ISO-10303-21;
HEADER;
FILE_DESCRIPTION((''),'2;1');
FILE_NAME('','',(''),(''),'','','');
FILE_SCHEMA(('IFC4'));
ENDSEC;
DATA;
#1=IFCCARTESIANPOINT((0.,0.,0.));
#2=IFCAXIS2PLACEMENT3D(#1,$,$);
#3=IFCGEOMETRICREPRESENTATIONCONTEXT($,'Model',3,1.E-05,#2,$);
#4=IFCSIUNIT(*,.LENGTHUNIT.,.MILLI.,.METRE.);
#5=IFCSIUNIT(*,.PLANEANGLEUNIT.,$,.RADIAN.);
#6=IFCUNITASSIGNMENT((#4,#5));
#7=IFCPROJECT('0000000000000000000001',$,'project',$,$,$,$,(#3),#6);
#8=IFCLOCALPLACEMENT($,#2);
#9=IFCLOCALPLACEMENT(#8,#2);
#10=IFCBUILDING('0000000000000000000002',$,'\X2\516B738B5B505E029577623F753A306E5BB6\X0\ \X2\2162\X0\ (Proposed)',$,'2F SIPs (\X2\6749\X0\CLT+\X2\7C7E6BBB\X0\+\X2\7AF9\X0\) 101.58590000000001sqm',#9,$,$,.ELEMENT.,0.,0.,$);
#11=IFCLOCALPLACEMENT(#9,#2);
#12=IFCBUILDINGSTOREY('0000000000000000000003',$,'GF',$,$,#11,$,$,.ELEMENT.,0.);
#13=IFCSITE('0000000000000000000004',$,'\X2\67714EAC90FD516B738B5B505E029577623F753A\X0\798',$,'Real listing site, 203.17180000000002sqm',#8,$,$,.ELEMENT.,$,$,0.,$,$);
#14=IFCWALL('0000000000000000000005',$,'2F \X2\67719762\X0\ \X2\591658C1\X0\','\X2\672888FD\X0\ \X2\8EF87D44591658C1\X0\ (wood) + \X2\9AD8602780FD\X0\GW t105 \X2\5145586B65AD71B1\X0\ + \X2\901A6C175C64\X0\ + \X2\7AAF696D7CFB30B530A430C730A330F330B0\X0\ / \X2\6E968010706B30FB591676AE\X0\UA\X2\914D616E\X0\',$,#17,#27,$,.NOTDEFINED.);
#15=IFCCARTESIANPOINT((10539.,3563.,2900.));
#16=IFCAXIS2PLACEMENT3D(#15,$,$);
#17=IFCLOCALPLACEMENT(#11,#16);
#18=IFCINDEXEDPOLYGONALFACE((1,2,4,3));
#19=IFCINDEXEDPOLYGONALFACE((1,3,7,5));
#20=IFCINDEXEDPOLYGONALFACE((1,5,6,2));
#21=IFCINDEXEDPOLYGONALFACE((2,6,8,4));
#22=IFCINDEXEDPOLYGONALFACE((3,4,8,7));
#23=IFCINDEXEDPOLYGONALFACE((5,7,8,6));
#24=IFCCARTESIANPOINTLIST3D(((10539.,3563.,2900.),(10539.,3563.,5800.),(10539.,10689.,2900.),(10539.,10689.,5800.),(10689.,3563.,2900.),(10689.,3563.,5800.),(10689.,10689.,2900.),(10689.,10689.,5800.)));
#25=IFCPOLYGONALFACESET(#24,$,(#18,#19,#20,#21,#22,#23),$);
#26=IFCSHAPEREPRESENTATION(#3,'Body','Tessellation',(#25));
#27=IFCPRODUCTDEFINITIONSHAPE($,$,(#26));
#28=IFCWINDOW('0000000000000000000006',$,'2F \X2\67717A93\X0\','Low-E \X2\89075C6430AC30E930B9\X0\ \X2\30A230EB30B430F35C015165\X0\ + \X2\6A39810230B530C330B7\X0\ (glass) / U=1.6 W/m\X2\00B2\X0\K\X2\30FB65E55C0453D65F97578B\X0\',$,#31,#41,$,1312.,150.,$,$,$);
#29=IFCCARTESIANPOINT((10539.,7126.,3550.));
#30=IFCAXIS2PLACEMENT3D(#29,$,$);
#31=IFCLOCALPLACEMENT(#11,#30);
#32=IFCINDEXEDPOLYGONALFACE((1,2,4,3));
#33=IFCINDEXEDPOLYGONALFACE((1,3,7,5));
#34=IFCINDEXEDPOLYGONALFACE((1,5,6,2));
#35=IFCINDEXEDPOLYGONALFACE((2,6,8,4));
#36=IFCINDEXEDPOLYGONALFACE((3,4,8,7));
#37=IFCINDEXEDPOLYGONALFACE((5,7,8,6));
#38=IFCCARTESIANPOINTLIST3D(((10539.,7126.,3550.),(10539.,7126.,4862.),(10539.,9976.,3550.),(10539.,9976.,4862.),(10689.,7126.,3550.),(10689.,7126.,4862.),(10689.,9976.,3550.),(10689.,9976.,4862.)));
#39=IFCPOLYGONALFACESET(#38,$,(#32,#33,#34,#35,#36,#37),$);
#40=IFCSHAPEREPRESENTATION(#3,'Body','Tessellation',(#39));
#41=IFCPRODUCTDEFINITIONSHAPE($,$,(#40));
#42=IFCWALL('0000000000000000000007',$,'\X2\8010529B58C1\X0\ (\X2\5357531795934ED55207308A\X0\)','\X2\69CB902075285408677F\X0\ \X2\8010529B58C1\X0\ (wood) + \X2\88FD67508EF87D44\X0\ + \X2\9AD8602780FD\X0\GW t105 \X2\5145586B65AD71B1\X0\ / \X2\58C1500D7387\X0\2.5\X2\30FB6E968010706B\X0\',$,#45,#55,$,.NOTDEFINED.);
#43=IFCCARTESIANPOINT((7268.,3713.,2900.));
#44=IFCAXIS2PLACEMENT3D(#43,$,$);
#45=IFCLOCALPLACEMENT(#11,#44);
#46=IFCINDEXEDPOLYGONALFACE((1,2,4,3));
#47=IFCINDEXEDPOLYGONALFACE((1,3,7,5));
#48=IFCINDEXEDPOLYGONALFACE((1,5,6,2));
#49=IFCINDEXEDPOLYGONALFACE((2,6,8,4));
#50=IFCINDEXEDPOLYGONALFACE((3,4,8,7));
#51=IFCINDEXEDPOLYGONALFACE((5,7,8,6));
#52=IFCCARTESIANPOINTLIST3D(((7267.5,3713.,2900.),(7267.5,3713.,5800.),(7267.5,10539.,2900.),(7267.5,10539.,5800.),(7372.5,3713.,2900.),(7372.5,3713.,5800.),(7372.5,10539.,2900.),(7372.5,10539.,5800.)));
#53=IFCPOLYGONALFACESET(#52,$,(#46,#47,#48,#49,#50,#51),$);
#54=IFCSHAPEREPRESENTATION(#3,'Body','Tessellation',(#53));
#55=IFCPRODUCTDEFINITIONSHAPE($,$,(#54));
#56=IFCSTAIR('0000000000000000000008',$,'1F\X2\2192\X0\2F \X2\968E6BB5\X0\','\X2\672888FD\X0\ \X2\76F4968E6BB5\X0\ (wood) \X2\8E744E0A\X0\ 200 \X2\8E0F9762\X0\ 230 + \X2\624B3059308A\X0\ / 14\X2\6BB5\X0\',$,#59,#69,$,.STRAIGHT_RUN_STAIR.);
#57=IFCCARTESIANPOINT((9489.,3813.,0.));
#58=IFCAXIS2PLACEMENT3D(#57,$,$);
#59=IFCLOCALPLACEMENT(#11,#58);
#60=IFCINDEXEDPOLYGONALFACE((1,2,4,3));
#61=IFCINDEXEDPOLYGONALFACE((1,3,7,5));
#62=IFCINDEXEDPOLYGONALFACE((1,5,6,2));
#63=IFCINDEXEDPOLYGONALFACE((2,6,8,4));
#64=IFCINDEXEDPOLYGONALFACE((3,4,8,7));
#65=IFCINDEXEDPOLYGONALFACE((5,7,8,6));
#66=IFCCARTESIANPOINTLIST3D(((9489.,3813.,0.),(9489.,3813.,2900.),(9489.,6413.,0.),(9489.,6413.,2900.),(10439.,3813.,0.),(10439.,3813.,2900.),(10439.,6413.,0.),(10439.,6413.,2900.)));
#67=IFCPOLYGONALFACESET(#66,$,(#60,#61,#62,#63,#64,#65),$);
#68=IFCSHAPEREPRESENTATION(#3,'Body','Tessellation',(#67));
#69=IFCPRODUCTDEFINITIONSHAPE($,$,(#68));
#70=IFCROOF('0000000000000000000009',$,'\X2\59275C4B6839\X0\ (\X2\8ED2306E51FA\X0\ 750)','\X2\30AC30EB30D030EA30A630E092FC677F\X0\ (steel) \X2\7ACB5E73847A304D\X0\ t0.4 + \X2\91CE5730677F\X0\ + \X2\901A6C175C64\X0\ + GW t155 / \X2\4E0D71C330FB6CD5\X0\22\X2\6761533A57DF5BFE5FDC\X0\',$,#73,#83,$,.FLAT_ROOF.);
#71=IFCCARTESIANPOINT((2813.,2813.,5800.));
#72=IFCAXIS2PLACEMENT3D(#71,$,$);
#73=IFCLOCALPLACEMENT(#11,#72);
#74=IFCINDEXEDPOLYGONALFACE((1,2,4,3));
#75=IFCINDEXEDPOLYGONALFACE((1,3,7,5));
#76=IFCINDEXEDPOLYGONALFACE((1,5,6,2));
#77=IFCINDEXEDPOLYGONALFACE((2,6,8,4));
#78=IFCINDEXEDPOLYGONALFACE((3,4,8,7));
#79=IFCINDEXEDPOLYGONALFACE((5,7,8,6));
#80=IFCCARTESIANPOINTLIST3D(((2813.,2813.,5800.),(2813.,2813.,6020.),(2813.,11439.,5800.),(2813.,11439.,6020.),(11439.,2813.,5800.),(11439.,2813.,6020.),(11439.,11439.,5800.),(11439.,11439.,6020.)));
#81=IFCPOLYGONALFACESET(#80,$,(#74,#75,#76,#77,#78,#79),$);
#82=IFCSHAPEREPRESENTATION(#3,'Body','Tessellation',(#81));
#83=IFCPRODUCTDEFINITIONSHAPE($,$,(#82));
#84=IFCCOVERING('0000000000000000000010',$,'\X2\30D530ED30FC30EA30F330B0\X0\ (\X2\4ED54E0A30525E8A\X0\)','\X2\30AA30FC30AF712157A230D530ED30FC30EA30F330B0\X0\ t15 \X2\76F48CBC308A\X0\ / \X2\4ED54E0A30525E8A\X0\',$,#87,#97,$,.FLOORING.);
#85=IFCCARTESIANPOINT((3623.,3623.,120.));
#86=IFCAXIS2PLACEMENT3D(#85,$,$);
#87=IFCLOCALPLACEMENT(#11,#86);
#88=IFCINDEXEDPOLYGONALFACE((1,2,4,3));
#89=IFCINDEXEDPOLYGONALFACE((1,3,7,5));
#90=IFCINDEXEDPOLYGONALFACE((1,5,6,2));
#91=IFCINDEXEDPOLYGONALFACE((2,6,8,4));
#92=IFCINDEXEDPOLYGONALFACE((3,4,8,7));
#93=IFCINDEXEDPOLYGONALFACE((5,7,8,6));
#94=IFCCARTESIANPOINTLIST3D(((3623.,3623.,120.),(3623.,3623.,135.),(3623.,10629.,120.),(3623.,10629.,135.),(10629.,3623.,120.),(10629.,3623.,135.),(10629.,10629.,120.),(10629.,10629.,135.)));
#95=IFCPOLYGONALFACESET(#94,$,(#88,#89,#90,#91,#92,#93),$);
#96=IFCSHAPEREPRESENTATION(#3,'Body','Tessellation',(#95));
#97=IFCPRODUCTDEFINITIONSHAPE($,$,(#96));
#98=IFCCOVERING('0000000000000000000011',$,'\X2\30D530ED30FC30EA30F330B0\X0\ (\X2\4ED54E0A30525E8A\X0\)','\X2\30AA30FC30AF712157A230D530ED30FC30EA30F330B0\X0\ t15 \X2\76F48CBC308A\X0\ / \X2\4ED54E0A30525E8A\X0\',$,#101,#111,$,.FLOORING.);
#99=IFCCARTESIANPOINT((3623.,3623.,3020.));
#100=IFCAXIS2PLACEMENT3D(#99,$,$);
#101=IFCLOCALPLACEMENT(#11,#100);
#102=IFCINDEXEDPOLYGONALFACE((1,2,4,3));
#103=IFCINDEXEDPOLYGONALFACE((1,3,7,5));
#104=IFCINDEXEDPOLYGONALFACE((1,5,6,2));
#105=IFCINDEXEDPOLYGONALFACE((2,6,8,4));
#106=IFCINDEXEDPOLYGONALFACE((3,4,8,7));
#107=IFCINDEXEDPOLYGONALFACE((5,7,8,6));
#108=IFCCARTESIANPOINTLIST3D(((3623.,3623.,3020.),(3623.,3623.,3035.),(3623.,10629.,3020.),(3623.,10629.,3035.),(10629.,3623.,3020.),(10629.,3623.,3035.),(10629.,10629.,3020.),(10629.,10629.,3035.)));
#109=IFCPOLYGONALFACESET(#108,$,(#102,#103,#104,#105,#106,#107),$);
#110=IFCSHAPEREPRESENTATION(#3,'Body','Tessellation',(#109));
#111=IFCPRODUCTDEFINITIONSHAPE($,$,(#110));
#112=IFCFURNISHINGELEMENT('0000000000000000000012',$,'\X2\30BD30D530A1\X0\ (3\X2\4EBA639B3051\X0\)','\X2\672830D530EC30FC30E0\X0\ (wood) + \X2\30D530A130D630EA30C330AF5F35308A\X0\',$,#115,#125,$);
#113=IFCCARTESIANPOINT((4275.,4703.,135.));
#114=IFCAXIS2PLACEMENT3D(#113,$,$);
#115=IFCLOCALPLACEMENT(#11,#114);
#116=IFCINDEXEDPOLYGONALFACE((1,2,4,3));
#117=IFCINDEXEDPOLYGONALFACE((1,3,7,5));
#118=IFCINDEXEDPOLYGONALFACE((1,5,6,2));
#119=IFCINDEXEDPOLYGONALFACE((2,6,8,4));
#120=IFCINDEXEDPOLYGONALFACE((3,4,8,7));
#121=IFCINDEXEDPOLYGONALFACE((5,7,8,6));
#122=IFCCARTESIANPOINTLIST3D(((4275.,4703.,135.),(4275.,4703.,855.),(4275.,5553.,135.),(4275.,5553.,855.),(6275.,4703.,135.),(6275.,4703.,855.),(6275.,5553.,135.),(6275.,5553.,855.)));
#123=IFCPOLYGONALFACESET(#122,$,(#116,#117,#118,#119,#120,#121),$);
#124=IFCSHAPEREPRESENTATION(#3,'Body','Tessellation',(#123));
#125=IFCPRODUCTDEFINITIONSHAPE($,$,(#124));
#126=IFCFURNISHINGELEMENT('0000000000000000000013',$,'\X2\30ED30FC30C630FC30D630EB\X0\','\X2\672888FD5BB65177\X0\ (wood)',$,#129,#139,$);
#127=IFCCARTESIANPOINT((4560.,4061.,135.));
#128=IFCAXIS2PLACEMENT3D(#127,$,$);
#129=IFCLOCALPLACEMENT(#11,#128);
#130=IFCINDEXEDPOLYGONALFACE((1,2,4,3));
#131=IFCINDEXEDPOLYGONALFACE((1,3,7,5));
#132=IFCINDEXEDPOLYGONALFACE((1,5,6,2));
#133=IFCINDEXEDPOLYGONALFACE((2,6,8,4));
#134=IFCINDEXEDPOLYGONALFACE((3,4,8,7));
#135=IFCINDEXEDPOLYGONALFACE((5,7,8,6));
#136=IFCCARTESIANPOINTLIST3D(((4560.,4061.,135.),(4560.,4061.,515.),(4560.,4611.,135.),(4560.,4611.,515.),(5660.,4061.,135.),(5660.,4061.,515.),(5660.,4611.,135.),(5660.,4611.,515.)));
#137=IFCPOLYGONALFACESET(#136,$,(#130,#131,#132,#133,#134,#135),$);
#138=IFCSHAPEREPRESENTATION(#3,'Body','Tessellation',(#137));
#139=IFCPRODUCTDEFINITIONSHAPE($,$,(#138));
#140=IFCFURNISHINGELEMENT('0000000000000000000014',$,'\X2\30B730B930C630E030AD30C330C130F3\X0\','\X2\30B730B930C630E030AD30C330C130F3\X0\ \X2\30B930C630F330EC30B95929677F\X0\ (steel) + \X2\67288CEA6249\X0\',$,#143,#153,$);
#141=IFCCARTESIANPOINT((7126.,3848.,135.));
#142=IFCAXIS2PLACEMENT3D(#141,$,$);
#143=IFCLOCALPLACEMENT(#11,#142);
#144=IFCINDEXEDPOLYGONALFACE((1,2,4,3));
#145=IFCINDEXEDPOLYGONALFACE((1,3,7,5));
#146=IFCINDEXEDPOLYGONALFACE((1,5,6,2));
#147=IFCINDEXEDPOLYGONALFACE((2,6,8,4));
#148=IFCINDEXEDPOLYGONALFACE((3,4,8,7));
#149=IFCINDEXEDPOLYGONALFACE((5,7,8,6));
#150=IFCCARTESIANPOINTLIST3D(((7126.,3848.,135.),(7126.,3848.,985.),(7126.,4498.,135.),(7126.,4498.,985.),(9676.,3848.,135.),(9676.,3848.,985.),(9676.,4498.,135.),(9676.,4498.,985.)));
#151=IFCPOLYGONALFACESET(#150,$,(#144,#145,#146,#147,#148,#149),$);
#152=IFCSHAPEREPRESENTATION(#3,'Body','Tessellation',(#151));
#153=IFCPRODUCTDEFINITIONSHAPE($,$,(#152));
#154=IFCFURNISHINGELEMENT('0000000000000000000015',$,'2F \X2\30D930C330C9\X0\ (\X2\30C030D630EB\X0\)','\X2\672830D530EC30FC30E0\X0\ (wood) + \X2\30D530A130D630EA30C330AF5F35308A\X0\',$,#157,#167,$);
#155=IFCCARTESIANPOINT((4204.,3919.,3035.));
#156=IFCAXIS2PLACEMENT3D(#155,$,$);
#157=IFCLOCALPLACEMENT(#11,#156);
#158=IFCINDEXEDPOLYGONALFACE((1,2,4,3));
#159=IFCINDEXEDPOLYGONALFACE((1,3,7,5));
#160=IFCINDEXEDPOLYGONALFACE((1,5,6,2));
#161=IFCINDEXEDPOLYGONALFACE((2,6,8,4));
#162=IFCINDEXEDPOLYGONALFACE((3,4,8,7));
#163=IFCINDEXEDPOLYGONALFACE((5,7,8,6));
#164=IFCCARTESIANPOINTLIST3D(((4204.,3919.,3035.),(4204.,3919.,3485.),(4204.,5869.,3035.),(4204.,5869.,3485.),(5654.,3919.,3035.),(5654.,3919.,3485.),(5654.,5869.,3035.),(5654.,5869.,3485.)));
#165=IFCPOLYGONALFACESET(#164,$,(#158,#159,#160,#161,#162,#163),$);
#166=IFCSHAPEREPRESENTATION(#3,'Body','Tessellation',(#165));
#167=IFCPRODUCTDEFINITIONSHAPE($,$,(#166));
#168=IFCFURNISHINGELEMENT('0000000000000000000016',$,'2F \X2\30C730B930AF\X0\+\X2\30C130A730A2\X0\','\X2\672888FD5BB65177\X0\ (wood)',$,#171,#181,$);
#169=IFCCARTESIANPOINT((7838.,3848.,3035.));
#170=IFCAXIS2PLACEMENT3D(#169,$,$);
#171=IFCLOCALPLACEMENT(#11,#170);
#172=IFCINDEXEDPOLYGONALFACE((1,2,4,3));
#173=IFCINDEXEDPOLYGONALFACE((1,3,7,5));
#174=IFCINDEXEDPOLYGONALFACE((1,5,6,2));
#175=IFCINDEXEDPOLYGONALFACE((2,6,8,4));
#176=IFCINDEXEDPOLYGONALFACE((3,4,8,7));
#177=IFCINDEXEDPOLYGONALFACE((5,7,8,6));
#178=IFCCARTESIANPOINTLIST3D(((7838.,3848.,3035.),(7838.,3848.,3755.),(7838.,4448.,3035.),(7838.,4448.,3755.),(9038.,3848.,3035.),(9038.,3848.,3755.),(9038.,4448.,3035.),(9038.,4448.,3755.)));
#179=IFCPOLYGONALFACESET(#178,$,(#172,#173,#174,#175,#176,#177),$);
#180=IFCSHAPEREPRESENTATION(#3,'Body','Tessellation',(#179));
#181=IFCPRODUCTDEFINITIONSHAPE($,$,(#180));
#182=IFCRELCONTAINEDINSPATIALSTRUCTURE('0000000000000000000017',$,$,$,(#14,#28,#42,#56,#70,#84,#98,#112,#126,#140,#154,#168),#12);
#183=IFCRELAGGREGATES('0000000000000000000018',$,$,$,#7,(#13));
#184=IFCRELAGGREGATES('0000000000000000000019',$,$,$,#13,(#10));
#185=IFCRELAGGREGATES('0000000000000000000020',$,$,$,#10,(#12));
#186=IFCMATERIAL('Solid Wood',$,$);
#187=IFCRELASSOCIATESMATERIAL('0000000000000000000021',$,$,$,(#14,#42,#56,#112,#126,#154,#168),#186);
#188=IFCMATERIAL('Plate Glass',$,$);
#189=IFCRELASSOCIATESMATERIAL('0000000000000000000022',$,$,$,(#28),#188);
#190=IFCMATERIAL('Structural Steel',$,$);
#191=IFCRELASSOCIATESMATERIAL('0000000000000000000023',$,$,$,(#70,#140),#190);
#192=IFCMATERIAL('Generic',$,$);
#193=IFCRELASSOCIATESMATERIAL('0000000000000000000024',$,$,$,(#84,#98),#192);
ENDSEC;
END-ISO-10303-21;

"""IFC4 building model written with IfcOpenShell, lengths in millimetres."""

from ifc_helpers import new_model, si_unit, frame, frame_2d, origin, place, context, project, spatial, rectangle, extrude, material, element, fill, save


model = new_model("IFC4")

# Units and contexts
model_context = context("Model", 3, precision=1e-05, world=origin())
ifc_project = project(units=[si_unit("LENGTHUNIT", "METRE", prefix="MILLI"), si_unit("PLANEANGLEUNIT", "RADIAN")], contexts=[model_context])

# Site, building, storey
site_placement = place(None, origin())
site = spatial("IfcSite", under=ifc_project, at=site_placement, Name="東京都八王子市長房町798", ObjectType="Real listing site, 203.17180000000002sqm", CompositionType="ELEMENT", RefElevation=0.0)
building_placement = place(site_placement, origin())
building = spatial("IfcBuilding", under=site, at=building_placement, Name="八王子市長房町の家 Ⅲ (Proposed)", ObjectType="2F SIPs (杉CLT+籾殻+竹) 101.58590000000001sqm", CompositionType="ELEMENT", ElevationOfRefHeight=0.0, ElevationOfTerrain=0.0)
storey_placement = place(building_placement, origin())
storey = spatial("IfcBuildingStorey", under=building, at=storey_placement, Name="GF", CompositionType="ELEMENT", Elevation=0.0)

# Shared definitions
ifc_material_1 = material(Name="Solid Wood")

# Shared definitions
ifc_material_2 = material(Name="Plate Glass")

# Wall, opening, window
wall_1_placement = place(storey_placement, frame((10539.0, 3563.0, 2900.0)))
wall_1 = element("IfcWall", 1, at=wall_1_placement, inside=storey, material=ifc_material_1, Name="2F 東面 外壁", Description="木製 軸組外壁 (wood) + 高性能GW t105 充填断熱 + 通気層 + 窯業系サイディング / 準耐火・外皮UA配慮", PredefinedType="NOTDEFINED", context=model_context, shape_type="SweptSolid", body=[
    extrude(rectangle(XDim=150.0, YDim=7126.0, at=frame_2d((75.0, 3563.0))), frame((10539.0, 3563.0, 2900.0)), (0.0, 0.0, 1.0), 2900.0),
])
opening_1_placement = place(storey_placement, frame((10539.0, 7126.0, 3550.0)))
opening_1 = element("IfcOpeningElement", 2, at=opening_1_placement, cuts=wall_1, PredefinedType="NOTDEFINED", context=model_context, shape_type="SweptSolid", body=[
    extrude(rectangle(XDim=150.0, YDim=2850.0, at=frame_2d((75.0, 1425.0))), frame((10539.0, 7126.0, 3550.0)), (0.0, 0.0, 1.0), 1312.0),
])
window_1_placement = place(storey_placement, frame((10539.0, 7126.0, 3550.0)))
window_1 = element("IfcWindow", 3, at=window_1_placement, inside=storey, material=ifc_material_2, Name="2F 東窓", Description="Low-E 複層ガラス アルゴン封入 + 樹脂サッシ (glass) / U=1.6 W/m²K・日射取得型", OverallHeight=1312.0, OverallWidth=150.0, context=model_context, shape_type="SweptSolid", body=[
    extrude(rectangle(XDim=150.0, YDim=2850.0, at=frame_2d((75.0, 1425.0))), frame((10539.0, 7126.0, 3550.0)), (0.0, 0.0, 1.0), 1312.0),
])
fill(opening_1, window_1)

# Wall
wall_2_placement = place(storey_placement, frame((7268.0, 3713.0, 2900.0)))
element("IfcWall", 4, at=wall_2_placement, inside=storey, material=ifc_material_1, Name="耐力壁 (南北間仕切り)", Description="構造用合板 耐力壁 (wood) + 製材軸組 + 高性能GW t105 充填断熱 / 壁倍率2.5・準耐火", PredefinedType="NOTDEFINED", context=model_context, shape_type="SweptSolid", body=[
    extrude(rectangle(XDim=105.0, YDim=6826.0, at=frame_2d((52.0, 3413.0))), frame((7268.0, 3713.0, 2900.0)), (0.0, 0.0, 1.0), 2900.0),
])

# Stair
stair_placement = place(storey_placement, frame((9489.0, 3813.0, 0.0)))
element("IfcStair", 5, at=stair_placement, inside=storey, material=ifc_material_1, Name="1F→2F 階段", Description="木製 直階段 (wood) 蹴上 200 踏面 230 + 手すり / 14段", PredefinedType="STRAIGHT_RUN_STAIR", context=model_context, shape_type="SweptSolid", body=[
    extrude(rectangle(XDim=950.0, YDim=2600.0, at=frame_2d((475.0, 1300.0))), frame((9489.0, 3813.0, 0.0)), (0.0, 0.0, 1.0), 2900.0),
])

# Roof
ifc_material_3 = material(Name="Structural Steel")
roof_placement = place(storey_placement, frame((2813.0, 2813.0, 5800.0)))
element("IfcRoof", 6, at=roof_placement, inside=storey, material=ifc_material_3, Name="大屋根 (軒の出 750)", Description="ガルバリウム鋼板 (steel) 立平葺き t0.4 + 野地板 + 通気層 + GW t155 / 不燃・法22条区域対応", PredefinedType="FLAT_ROOF", context=model_context, shape_type="SweptSolid", body=[
    extrude(rectangle(XDim=8626.0, YDim=8626.0, at=frame_2d((4313.0, 4313.0))), frame((2813.0, 2813.0, 5800.0)), (0.0, 0.0, 1.0), 220.0),
])

# Coverings
ifc_material_4 = material(Name="Generic")
covering_1_placement = place(storey_placement, frame((3623.0, 3623.0, 120.0)))
element("IfcCovering", 7, at=covering_1_placement, inside=storey, material=ifc_material_4, Name="フローリング (仕上げ床)", Description="オーク無垢フローリング t15 直貼り / 仕上げ床", PredefinedType="FLOORING", context=model_context, shape_type="SweptSolid", body=[
    extrude(rectangle(XDim=7006.0, YDim=7006.0, at=frame_2d((3503.0, 3503.0))), frame((3623.0, 3623.0, 120.0)), (0.0, 0.0, 1.0), 15.0),
])
covering_2_placement = place(storey_placement, frame((3623.0, 3623.0, 3020.0)))
element("IfcCovering", 8, at=covering_2_placement, inside=storey, material=ifc_material_4, Name="フローリング (仕上げ床)", Description="オーク無垢フローリング t15 直貼り / 仕上げ床", PredefinedType="FLOORING", context=model_context, shape_type="SweptSolid", body=[
    extrude(rectangle(XDim=7006.0, YDim=7006.0, at=frame_2d((3503.0, 3503.0))), frame((3623.0, 3623.0, 3020.0)), (0.0, 0.0, 1.0), 15.0),
])

# Furnishing elements
furnishing_1_placement = place(storey_placement, frame((4275.0, 4703.0, 135.0)))
element("IfcFurnishingElement", 9, at=furnishing_1_placement, inside=storey, material=ifc_material_1, Name="ソファ (3人掛け)", Description="木フレーム (wood) + ファブリック張り", context=model_context, shape_type="SweptSolid", body=[
    extrude(rectangle(XDim=2000.0, YDim=850.0, at=frame_2d((1000.0, 425.0))), frame((4275.0, 4703.0, 135.0)), (0.0, 0.0, 1.0), 720.0),
])
furnishing_2_placement = place(storey_placement, frame((4560.0, 4061.0, 135.0)))
element("IfcFurnishingElement", 10, at=furnishing_2_placement, inside=storey, material=ifc_material_1, Name="ローテーブル", Description="木製家具 (wood)", context=model_context, shape_type="SweptSolid", body=[
    extrude(rectangle(XDim=1100.0, YDim=550.0, at=frame_2d((550.0, 275.0))), frame((4560.0, 4061.0, 135.0)), (0.0, 0.0, 1.0), 380.0),
])
furnishing_3_placement = place(storey_placement, frame((7126.0, 3848.0, 135.0)))
element("IfcFurnishingElement", 11, at=furnishing_3_placement, inside=storey, material=ifc_material_3, Name="システムキッチン", Description="システムキッチン ステンレス天板 (steel) + 木質扉", context=model_context, shape_type="SweptSolid", body=[
    extrude(rectangle(XDim=2550.0, YDim=650.0, at=frame_2d((1275.0, 325.0))), frame((7126.0, 3848.0, 135.0)), (0.0, 0.0, 1.0), 850.0),
])
furnishing_4_placement = place(storey_placement, frame((4204.0, 3919.0, 3035.0)))
element("IfcFurnishingElement", 12, at=furnishing_4_placement, inside=storey, material=ifc_material_1, Name="2F ベッド (ダブル)", Description="木フレーム (wood) + ファブリック張り", context=model_context, shape_type="SweptSolid", body=[
    extrude(rectangle(XDim=1450.0, YDim=1950.0, at=frame_2d((725.0, 975.0))), frame((4204.0, 3919.0, 3035.0)), (0.0, 0.0, 1.0), 450.0),
])
furnishing_5_placement = place(storey_placement, frame((7838.0, 3848.0, 3035.0)))
element("IfcFurnishingElement", 13, at=furnishing_5_placement, inside=storey, material=ifc_material_1, Name="2F デスク+チェア", Description="木製家具 (wood)", context=model_context, shape_type="SweptSolid", body=[
    extrude(rectangle(XDim=1200.0, YDim=600.0, at=frame_2d((600.0, 300.0))), frame((7838.0, 3848.0, 3035.0)), (0.0, 0.0, 1.0), 720.0),
])

save(model, "model.ifc")
